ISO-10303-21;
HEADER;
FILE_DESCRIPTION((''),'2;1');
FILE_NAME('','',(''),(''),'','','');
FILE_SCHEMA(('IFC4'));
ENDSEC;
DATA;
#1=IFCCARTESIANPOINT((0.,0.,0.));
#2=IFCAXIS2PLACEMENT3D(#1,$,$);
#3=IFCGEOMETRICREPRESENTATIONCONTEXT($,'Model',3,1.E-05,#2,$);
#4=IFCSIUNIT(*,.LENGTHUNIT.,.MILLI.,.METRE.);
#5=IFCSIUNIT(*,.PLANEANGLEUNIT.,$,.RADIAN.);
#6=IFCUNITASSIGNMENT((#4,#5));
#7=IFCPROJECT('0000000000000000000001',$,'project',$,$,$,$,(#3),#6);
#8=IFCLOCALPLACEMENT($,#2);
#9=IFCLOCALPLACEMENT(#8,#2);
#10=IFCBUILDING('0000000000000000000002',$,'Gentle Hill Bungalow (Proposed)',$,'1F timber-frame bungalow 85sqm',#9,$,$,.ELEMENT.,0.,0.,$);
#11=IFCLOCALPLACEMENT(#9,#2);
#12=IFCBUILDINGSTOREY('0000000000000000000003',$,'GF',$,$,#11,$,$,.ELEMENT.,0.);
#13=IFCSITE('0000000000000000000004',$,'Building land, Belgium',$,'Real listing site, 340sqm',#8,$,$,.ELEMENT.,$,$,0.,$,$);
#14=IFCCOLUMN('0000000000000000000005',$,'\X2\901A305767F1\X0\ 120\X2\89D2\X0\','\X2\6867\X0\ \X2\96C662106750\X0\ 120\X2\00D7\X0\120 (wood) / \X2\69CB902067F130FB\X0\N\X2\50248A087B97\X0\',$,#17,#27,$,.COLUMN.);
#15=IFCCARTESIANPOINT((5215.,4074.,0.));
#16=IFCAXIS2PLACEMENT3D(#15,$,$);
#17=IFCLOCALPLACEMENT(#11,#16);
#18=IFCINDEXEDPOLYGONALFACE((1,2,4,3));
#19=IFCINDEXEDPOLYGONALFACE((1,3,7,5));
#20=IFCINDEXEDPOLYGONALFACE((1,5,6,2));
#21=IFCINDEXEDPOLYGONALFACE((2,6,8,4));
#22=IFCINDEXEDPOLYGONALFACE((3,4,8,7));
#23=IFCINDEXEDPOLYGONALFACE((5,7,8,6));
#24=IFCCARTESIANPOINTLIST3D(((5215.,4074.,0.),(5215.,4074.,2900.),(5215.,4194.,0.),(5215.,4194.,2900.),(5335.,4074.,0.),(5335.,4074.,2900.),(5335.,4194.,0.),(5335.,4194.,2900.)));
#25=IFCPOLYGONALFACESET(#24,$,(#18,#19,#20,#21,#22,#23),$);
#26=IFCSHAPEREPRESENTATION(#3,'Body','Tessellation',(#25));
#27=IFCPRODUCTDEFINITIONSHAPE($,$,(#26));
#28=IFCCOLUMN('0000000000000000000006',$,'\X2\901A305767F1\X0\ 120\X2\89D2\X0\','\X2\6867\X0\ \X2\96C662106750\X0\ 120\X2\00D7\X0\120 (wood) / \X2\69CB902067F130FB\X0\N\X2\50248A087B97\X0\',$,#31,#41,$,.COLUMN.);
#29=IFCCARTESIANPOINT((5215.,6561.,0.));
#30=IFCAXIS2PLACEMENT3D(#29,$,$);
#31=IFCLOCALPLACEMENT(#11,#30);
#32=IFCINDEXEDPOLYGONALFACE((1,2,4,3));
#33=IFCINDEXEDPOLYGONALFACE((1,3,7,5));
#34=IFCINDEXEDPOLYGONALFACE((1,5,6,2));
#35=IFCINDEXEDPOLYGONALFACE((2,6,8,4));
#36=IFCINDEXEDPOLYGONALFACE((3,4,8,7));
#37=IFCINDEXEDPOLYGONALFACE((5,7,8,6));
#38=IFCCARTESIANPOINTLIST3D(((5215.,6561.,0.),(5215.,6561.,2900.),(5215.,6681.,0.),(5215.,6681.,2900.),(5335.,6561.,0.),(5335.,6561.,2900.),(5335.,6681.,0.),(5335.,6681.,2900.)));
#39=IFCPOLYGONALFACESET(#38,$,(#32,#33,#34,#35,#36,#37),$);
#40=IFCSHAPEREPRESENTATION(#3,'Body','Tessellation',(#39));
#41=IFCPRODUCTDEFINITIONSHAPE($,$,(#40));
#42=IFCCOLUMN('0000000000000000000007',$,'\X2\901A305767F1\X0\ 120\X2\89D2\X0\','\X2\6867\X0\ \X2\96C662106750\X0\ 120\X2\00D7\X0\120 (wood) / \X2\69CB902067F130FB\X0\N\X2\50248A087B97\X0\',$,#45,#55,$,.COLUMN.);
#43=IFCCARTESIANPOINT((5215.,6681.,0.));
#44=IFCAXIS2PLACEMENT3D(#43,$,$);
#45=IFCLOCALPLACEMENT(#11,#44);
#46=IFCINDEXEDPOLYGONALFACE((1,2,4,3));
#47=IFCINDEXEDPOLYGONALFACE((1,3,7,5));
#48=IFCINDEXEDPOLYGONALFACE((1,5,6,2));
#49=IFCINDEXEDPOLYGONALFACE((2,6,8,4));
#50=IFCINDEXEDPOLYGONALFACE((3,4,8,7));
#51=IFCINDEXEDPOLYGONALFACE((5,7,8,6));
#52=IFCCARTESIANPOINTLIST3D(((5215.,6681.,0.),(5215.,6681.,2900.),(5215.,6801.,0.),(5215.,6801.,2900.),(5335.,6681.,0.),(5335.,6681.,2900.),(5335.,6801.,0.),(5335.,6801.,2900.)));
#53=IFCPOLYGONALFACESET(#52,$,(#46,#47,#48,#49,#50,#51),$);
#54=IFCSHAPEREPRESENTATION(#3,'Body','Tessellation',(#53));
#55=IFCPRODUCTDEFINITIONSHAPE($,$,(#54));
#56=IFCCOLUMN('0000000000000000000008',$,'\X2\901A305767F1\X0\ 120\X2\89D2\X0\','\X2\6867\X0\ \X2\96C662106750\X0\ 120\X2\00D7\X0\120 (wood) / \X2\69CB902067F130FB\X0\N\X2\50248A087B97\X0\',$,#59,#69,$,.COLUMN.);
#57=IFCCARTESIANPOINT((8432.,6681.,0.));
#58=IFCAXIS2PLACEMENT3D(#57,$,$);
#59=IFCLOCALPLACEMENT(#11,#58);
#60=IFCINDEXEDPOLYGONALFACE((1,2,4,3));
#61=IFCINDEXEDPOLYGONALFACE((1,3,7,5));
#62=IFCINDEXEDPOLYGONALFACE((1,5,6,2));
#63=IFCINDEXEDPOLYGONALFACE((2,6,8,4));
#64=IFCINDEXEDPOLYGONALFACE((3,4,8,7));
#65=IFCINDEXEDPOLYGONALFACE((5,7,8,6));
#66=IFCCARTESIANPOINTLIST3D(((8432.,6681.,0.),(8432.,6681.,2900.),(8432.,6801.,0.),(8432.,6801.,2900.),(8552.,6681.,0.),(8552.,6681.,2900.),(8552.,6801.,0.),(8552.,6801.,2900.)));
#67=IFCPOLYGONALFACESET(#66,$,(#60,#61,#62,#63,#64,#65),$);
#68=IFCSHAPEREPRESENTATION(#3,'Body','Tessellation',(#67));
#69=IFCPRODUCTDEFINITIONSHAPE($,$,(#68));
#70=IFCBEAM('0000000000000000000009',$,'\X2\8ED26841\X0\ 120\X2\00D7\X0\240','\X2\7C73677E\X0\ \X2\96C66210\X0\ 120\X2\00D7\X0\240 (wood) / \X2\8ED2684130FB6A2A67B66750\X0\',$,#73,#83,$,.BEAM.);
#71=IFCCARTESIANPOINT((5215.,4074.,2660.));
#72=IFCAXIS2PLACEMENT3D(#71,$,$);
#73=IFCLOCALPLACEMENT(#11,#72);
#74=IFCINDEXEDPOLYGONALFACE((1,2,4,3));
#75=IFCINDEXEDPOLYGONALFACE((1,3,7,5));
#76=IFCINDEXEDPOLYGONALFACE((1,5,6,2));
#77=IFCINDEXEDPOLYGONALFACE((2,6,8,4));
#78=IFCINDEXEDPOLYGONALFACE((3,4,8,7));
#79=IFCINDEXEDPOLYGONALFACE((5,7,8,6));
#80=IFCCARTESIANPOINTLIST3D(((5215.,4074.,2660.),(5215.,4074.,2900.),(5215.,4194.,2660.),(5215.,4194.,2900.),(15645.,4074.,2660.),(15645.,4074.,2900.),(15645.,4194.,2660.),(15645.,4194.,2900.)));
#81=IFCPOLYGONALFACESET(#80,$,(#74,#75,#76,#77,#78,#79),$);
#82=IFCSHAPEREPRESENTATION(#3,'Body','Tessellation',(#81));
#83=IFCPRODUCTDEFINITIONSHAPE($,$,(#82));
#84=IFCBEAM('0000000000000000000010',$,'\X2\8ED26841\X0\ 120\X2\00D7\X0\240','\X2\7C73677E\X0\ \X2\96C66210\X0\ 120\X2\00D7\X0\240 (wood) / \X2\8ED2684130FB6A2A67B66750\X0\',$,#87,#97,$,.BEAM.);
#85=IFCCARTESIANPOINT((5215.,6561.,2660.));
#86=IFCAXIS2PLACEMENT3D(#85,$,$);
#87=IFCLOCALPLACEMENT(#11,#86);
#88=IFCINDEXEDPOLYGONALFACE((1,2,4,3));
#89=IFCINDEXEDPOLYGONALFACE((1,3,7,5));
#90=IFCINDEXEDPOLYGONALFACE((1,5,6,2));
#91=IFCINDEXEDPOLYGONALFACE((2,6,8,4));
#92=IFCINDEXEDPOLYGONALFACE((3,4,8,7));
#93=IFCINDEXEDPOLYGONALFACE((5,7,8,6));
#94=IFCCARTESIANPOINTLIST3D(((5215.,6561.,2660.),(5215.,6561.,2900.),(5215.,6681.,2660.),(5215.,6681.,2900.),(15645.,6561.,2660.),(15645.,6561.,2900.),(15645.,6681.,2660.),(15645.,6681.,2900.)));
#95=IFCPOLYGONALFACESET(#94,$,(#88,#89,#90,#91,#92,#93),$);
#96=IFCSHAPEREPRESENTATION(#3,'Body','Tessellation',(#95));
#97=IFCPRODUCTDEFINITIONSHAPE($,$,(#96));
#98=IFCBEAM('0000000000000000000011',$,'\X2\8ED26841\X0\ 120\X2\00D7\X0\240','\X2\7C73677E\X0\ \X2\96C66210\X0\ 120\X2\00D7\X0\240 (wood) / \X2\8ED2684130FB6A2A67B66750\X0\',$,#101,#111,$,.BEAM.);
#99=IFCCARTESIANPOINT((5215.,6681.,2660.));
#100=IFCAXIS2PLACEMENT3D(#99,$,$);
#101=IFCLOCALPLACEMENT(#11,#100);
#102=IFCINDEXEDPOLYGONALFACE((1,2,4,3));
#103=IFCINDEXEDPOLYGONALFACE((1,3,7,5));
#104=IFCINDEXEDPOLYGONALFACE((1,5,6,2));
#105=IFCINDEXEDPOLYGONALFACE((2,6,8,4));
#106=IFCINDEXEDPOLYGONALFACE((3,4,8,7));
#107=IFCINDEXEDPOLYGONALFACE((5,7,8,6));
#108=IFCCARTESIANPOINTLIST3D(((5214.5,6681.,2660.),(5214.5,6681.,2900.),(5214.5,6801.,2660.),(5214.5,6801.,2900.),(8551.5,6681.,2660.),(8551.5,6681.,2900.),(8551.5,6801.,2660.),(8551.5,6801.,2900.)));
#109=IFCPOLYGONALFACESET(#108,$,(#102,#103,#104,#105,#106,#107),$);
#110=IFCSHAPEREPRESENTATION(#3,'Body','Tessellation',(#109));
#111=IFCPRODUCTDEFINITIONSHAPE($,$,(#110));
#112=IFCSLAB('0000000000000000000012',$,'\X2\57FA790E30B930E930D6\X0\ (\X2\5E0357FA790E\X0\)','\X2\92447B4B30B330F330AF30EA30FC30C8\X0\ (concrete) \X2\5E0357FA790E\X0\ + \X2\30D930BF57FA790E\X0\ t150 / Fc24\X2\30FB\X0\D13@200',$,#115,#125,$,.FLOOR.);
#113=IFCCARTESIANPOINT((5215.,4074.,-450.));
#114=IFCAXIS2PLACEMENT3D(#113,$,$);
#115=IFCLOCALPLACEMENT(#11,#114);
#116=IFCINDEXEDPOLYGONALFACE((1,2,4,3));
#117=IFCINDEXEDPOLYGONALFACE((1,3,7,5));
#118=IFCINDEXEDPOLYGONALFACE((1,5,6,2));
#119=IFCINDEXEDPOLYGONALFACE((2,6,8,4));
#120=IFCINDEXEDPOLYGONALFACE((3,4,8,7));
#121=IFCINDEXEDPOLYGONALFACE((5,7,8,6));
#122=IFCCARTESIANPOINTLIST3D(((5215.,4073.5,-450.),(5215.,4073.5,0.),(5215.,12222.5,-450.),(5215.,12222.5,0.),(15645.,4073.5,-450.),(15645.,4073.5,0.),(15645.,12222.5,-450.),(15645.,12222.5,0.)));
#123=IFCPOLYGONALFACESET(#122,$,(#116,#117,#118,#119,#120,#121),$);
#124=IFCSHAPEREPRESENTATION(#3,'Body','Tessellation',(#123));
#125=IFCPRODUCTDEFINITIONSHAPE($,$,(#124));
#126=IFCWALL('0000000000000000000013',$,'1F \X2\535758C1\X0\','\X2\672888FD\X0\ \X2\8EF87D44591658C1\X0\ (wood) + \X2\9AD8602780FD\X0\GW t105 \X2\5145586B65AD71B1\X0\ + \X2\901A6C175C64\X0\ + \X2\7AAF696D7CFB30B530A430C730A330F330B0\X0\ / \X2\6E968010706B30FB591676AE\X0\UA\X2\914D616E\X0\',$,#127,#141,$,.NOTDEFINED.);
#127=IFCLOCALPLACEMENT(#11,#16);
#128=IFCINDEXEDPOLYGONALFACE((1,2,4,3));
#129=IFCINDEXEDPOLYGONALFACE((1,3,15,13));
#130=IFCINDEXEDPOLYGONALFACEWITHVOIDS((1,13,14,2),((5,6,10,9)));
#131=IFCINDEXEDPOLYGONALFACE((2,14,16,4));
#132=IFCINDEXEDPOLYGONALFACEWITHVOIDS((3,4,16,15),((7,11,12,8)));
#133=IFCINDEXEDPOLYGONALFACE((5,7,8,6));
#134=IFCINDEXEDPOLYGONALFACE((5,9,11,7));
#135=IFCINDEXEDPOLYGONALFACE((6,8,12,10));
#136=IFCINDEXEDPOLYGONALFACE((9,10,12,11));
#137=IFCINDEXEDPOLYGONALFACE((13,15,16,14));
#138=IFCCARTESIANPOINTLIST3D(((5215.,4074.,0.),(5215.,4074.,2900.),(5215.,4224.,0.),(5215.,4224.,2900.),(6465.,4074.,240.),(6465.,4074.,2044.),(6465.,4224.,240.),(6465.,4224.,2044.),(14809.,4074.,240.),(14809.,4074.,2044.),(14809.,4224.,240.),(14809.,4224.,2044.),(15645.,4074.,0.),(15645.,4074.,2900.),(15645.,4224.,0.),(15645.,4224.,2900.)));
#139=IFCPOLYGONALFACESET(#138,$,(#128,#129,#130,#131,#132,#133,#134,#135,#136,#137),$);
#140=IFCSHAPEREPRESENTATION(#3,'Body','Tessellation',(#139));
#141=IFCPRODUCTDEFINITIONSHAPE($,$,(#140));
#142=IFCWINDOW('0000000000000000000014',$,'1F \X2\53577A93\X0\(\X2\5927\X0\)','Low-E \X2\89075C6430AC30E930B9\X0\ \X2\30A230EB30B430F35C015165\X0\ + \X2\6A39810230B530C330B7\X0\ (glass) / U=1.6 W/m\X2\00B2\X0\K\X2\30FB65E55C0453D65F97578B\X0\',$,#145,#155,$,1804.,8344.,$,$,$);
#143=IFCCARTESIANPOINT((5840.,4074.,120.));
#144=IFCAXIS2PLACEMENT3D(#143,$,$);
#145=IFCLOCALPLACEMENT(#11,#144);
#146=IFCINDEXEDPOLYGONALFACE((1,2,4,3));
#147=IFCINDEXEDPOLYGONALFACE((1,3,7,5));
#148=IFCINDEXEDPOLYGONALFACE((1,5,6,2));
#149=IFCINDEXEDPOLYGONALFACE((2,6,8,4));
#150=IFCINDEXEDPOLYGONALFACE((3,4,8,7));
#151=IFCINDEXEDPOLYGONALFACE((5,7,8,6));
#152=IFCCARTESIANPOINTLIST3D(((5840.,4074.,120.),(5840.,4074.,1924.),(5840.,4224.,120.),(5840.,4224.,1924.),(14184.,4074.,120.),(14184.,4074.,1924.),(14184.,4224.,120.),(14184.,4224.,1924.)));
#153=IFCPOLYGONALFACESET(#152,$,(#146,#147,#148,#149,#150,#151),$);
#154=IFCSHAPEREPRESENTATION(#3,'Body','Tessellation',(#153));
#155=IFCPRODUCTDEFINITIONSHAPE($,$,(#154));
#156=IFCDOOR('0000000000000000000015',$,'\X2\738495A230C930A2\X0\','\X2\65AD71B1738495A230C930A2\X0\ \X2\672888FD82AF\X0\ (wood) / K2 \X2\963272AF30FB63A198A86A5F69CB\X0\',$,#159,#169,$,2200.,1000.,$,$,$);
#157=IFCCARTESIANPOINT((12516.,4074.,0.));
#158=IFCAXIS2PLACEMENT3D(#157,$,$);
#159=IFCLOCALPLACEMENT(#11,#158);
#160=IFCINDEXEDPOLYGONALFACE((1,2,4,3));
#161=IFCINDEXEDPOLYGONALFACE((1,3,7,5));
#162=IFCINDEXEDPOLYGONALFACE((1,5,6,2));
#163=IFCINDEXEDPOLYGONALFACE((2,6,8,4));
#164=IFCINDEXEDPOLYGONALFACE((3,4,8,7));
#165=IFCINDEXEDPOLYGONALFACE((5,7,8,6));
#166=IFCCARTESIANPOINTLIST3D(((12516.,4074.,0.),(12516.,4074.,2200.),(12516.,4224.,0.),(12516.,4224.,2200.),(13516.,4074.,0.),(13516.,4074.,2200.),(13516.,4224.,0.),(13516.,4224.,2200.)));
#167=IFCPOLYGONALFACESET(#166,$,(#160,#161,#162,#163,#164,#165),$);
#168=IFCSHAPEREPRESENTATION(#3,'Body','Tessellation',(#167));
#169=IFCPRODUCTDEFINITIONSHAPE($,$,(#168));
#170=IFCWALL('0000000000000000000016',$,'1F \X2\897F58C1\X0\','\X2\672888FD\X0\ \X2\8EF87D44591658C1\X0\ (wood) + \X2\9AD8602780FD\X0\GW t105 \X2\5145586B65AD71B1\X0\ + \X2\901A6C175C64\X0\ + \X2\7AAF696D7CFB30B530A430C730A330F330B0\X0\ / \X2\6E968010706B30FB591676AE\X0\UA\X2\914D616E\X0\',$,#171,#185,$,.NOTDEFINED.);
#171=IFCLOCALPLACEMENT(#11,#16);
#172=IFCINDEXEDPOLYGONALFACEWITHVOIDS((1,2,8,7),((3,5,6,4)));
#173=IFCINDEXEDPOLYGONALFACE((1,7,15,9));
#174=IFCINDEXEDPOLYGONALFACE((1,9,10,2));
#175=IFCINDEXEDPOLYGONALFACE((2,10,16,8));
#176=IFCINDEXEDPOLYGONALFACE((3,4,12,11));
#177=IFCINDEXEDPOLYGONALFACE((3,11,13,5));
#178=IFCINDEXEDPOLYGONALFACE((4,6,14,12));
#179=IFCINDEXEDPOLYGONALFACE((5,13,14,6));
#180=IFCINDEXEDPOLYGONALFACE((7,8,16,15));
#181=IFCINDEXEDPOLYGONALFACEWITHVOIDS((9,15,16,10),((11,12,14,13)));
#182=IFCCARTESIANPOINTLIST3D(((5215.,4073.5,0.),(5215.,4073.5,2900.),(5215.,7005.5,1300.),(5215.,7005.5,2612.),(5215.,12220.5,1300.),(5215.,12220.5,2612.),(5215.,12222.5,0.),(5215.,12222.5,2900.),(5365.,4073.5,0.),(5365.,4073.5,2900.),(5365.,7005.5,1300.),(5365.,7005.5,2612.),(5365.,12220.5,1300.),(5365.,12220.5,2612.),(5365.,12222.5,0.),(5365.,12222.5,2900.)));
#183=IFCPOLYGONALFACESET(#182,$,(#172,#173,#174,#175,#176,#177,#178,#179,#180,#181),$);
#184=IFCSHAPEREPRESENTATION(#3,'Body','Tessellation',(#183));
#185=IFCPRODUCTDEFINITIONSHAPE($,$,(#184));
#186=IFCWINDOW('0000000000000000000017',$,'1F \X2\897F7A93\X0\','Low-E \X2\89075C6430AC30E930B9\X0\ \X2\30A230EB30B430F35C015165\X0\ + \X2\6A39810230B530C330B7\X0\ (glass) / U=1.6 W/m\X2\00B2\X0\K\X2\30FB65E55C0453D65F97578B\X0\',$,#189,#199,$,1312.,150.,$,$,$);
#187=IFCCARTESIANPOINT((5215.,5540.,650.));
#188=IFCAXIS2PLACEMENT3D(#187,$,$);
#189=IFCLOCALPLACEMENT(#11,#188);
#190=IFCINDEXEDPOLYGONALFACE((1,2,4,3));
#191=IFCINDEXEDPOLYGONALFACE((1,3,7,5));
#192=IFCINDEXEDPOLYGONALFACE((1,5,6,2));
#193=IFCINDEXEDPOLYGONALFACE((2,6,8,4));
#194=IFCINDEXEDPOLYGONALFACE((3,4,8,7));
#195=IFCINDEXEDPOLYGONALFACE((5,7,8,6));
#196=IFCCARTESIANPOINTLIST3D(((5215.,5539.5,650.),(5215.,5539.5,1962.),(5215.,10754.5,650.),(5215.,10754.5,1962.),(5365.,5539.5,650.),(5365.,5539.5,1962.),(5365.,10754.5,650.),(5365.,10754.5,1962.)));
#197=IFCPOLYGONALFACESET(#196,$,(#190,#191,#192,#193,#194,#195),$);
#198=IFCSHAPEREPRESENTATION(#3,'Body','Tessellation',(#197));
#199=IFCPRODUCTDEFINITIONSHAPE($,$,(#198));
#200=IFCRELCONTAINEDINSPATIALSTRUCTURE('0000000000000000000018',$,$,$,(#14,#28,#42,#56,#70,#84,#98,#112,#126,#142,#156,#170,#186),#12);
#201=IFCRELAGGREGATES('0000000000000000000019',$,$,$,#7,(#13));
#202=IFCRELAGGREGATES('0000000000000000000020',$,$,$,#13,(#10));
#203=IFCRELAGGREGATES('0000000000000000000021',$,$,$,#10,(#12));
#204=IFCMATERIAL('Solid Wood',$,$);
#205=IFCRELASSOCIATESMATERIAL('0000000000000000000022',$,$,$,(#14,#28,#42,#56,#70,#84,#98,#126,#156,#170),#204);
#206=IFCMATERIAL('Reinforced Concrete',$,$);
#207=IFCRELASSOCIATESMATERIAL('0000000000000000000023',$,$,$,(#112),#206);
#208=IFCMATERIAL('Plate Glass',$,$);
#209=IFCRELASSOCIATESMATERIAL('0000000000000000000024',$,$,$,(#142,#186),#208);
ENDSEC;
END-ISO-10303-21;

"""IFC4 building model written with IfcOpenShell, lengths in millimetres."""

from ifc_helpers import new_model, si_unit, frame, frame_2d, origin, place, context, project, spatial, rectangle, extrude, material, element, fill, save


model = new_model("IFC4")

# Units and contexts
model_context = context("Model", 3, precision=1e-05, world=origin())
ifc_project = project(units=[si_unit("LENGTHUNIT", "METRE", prefix="MILLI"), si_unit("PLANEANGLEUNIT", "RADIAN")], contexts=[model_context])

# Site, building, storey
site_placement = place(None, origin())
site = spatial("IfcSite", under=ifc_project, at=site_placement, Name="Building land, Belgium", ObjectType="Real listing site, 340sqm", CompositionType="ELEMENT", RefElevation=0.0)
building_placement = place(site_placement, origin())
building = spatial("IfcBuilding", under=site, at=building_placement, Name="Gentle Hill Bungalow (Proposed)", ObjectType="1F timber-frame bungalow 85sqm", CompositionType="ELEMENT", ElevationOfRefHeight=0.0, ElevationOfTerrain=0.0)
storey_placement = place(building_placement, origin())
storey = spatial("IfcBuildingStorey", under=building, at=storey_placement, Name="GF", CompositionType="ELEMENT", Elevation=0.0)

# Columns
ifc_material_1 = material(Name="Solid Wood")
column_1_placement = place(storey_placement, frame((5215.0, 4074.0, 0.0)))
element("IfcColumn", 1, at=column_1_placement, inside=storey, material=ifc_material_1, Name="通し柱 120角", Description="桧 集成材 120×120 (wood) / 構造柱・N値計算", PredefinedType="COLUMN", context=model_context, shape_type="SweptSolid", body=[
    extrude(rectangle(XDim=120.0, YDim=120.0, at=frame_2d((60.0, 60.0))), frame((5215.0, 4074.0, 0.0)), (0.0, 0.0, 1.0), 2900.0),
])
column_2_placement = place(storey_placement, frame((5215.0, 6561.0, 0.0)))
element("IfcColumn", 2, at=column_2_placement, inside=storey, material=ifc_material_1, Name="通し柱 120角", Description="桧 集成材 120×120 (wood) / 構造柱・N値計算", PredefinedType="COLUMN", context=model_context, shape_type="SweptSolid", body=[
    extrude(rectangle(XDim=120.0, YDim=120.0, at=frame_2d((60.0, 60.0))), frame((5215.0, 6561.0, 0.0)), (0.0, 0.0, 1.0), 2900.0),
])
column_3_placement = place(storey_placement, frame((5215.0, 6681.0, 0.0)))
element("IfcColumn", 3, at=column_3_placement, inside=storey, material=ifc_material_1, Name="通し柱 120角", Description="桧 集成材 120×120 (wood) / 構造柱・N値計算", PredefinedType="COLUMN", context=model_context, shape_type="SweptSolid", body=[
    extrude(rectangle(XDim=120.0, YDim=120.0, at=frame_2d((60.0, 60.0))), frame((5215.0, 6681.0, 0.0)), (0.0, 0.0, 1.0), 2900.0),
])
column_4_placement = place(storey_placement, frame((8432.0, 6681.0, 0.0)))
element("IfcColumn", 4, at=column_4_placement, inside=storey, material=ifc_material_1, Name="通し柱 120角", Description="桧 集成材 120×120 (wood) / 構造柱・N値計算", PredefinedType="COLUMN", context=model_context, shape_type="SweptSolid", body=[
    extrude(rectangle(XDim=120.0, YDim=120.0, at=frame_2d((60.0, 60.0))), frame((8432.0, 6681.0, 0.0)), (0.0, 0.0, 1.0), 2900.0),
])

# Beams
beam_1_placement = place(storey_placement, frame((5215.0, 4074.0, 2660.0)))
element("IfcBeam", 5, at=beam_1_placement, inside=storey, material=ifc_material_1, Name="軒桁 120×240", Description="米松 集成 120×240 (wood) / 軒桁・横架材", PredefinedType="BEAM", context=model_context, shape_type="SweptSolid", body=[
    extrude(rectangle(XDim=10430.0, YDim=120.0, at=frame_2d((5215.0, 60.0))), frame((5215.0, 4074.0, 2660.0)), (0.0, 0.0, 1.0), 240.0),
])
beam_2_placement = place(storey_placement, frame((5215.0, 6561.0, 2660.0)))
element("IfcBeam", 6, at=beam_2_placement, inside=storey, material=ifc_material_1, Name="軒桁 120×240", Description="米松 集成 120×240 (wood) / 軒桁・横架材", PredefinedType="BEAM", context=model_context, shape_type="SweptSolid", body=[
    extrude(rectangle(XDim=10430.0, YDim=120.0, at=frame_2d((5215.0, 60.0))), frame((5215.0, 6561.0, 2660.0)), (0.0, 0.0, 1.0), 240.0),
])
beam_3_placement = place(storey_placement, frame((5215.0, 6681.0, 2660.0)))
element("IfcBeam", 7, at=beam_3_placement, inside=storey, material=ifc_material_1, Name="軒桁 120×240", Description="米松 集成 120×240 (wood) / 軒桁・横架材", PredefinedType="BEAM", context=model_context, shape_type="SweptSolid", body=[
    extrude(rectangle(XDim=3337.0, YDim=120.0, at=frame_2d((1668.0, 60.0))), frame((5215.0, 6681.0, 2660.0)), (0.0, 0.0, 1.0), 240.0),
])

# Slab
ifc_material_2 = material(Name="Reinforced Concrete")
slab_1_placement = place(storey_placement, frame((5215.0, 4074.0, -450.0)))
element("IfcSlab", 8, at=slab_1_placement, inside=storey, material=ifc_material_2, Name="基礎スラブ (布基礎)", Description="鉄筋コンクリート (concrete) 布基礎 + ベタ基礎 t150 / Fc24・D13@200", PredefinedType="FLOOR", context=model_context, shape_type="SweptSolid", body=[
    extrude(rectangle(XDim=10430.0, YDim=8149.0, at=frame_2d((5215.0, 4074.0))), frame((5215.0, 4074.0, -450.0)), (0.0, 0.0, 1.0), 450.0),
])

# Wall, openings, window, door
wall_1_placement = place(storey_placement, frame((5215.0, 4074.0, 0.0)))
wall_1 = element("IfcWall", 9, at=wall_1_placement, inside=storey, material=ifc_material_1, Name="1F 南壁", Description="木製 軸組外壁 (wood) + 高性能GW t105 充填断熱 + 通気層 + 窯業系サイディング / 準耐火・外皮UA配慮", PredefinedType="NOTDEFINED", context=model_context, shape_type="SweptSolid", body=[
    extrude(rectangle(XDim=10430.0, YDim=150.0, at=frame_2d((5215.0, 75.0))), frame((5215.0, 4074.0, 0.0)), (0.0, 0.0, 1.0), 2900.0),
])
opening_1_placement = place(storey_placement, frame((5840.0, 4074.0, 120.0)))
opening_1 = element("IfcOpeningElement", 10, at=opening_1_placement, cuts=wall_1, PredefinedType="NOTDEFINED", context=model_context, shape_type="SweptSolid", body=[
    extrude(rectangle(XDim=8344.0, YDim=150.0, at=frame_2d((4172.0, 75.0))), frame((5840.0, 4074.0, 120.0)), (0.0, 0.0, 1.0), 1804.0),
])
opening_2_placement = place(storey_placement, frame((12516.0, 4074.0, 0.0)))
opening_2 = element("IfcOpeningElement", 11, at=opening_2_placement, cuts=wall_1, PredefinedType="NOTDEFINED", context=model_context, shape_type="SweptSolid", body=[
    extrude(rectangle(XDim=1000.0, YDim=150.0, at=frame_2d((500.0, 75.0))), frame((12516.0, 4074.0, 0.0)), (0.0, 0.0, 1.0), 2200.0),
])
ifc_material_3 = material(Name="Plate Glass")
window_1_placement = place(storey_placement, frame((5840.0, 4074.0, 120.0)))
window_1 = element("IfcWindow", 12, at=window_1_placement, inside=storey, material=ifc_material_3, Name="1F 南窓(大)", Description="Low-E 複層ガラス アルゴン封入 + 樹脂サッシ (glass) / U=1.6 W/m²K・日射取得型", OverallHeight=1804.0, OverallWidth=8344.0, context=model_context, shape_type="SweptSolid", body=[
    extrude(rectangle(XDim=8344.0, YDim=150.0, at=frame_2d((4172.0, 75.0))), frame((5840.0, 4074.0, 120.0)), (0.0, 0.0, 1.0), 1804.0),
])
fill(opening_1, window_1)
door_placement = place(storey_placement, frame((12516.0, 4074.0, 0.0)))
door = element("IfcDoor", 13, at=door_placement, inside=storey, material=ifc_material_1, Name="玄関ドア", Description="断熱玄関ドア 木製芯 (wood) / K2 防犯・採風機構", OverallHeight=2200.0, OverallWidth=1000.0, context=model_context, shape_type="SweptSolid", body=[
    extrude(rectangle(XDim=1000.0, YDim=150.0, at=frame_2d((500.0, 75.0))), frame((12516.0, 4074.0, 0.0)), (0.0, 0.0, 1.0), 2200.0),
])
fill(opening_2, door)

# Wall, opening, window
wall_2_placement = place(storey_placement, frame((5215.0, 4074.0, 0.0)))
wall_2 = element("IfcWall", 14, at=wall_2_placement, inside=storey, material=ifc_material_1, Name="1F 西壁", Description="木製 軸組外壁 (wood) + 高性能GW t105 充填断熱 + 通気層 + 窯業系サイディング / 準耐火・外皮UA配慮", PredefinedType="NOTDEFINED", context=model_context, shape_type="SweptSolid", body=[
    extrude(rectangle(XDim=150.0, YDim=8149.0, at=frame_2d((75.0, 4074.0))), frame((5215.0, 4074.0, 0.0)), (0.0, 0.0, 1.0), 2900.0),
])
opening_3_placement = place(storey_placement, frame((5215.0, 5540.0, 650.0)))
opening_3 = element("IfcOpeningElement", 15, at=opening_3_placement, cuts=wall_2, PredefinedType="NOTDEFINED", context=model_context, shape_type="SweptSolid", body=[
    extrude(rectangle(XDim=150.0, YDim=5215.0, at=frame_2d((75.0, 2607.0))), frame((5215.0, 5540.0, 650.0)), (0.0, 0.0, 1.0), 1312.0),
])
window_2_placement = place(storey_placement, frame((5215.0, 5540.0, 650.0)))
window_2 = element("IfcWindow", 16, at=window_2_placement, inside=storey, material=ifc_material_3, Name="1F 西窓", Description="Low-E 複層ガラス アルゴン封入 + 樹脂サッシ (glass) / U=1.6 W/m²K・日射取得型", OverallHeight=1312.0, OverallWidth=150.0, context=model_context, shape_type="SweptSolid", body=[
    extrude(rectangle(XDim=150.0, YDim=5215.0, at=frame_2d((75.0, 2607.0))), frame((5215.0, 5540.0, 650.0)), (0.0, 0.0, 1.0), 1312.0),
])
fill(opening_3, window_2)

save(model, "model.ifc")
